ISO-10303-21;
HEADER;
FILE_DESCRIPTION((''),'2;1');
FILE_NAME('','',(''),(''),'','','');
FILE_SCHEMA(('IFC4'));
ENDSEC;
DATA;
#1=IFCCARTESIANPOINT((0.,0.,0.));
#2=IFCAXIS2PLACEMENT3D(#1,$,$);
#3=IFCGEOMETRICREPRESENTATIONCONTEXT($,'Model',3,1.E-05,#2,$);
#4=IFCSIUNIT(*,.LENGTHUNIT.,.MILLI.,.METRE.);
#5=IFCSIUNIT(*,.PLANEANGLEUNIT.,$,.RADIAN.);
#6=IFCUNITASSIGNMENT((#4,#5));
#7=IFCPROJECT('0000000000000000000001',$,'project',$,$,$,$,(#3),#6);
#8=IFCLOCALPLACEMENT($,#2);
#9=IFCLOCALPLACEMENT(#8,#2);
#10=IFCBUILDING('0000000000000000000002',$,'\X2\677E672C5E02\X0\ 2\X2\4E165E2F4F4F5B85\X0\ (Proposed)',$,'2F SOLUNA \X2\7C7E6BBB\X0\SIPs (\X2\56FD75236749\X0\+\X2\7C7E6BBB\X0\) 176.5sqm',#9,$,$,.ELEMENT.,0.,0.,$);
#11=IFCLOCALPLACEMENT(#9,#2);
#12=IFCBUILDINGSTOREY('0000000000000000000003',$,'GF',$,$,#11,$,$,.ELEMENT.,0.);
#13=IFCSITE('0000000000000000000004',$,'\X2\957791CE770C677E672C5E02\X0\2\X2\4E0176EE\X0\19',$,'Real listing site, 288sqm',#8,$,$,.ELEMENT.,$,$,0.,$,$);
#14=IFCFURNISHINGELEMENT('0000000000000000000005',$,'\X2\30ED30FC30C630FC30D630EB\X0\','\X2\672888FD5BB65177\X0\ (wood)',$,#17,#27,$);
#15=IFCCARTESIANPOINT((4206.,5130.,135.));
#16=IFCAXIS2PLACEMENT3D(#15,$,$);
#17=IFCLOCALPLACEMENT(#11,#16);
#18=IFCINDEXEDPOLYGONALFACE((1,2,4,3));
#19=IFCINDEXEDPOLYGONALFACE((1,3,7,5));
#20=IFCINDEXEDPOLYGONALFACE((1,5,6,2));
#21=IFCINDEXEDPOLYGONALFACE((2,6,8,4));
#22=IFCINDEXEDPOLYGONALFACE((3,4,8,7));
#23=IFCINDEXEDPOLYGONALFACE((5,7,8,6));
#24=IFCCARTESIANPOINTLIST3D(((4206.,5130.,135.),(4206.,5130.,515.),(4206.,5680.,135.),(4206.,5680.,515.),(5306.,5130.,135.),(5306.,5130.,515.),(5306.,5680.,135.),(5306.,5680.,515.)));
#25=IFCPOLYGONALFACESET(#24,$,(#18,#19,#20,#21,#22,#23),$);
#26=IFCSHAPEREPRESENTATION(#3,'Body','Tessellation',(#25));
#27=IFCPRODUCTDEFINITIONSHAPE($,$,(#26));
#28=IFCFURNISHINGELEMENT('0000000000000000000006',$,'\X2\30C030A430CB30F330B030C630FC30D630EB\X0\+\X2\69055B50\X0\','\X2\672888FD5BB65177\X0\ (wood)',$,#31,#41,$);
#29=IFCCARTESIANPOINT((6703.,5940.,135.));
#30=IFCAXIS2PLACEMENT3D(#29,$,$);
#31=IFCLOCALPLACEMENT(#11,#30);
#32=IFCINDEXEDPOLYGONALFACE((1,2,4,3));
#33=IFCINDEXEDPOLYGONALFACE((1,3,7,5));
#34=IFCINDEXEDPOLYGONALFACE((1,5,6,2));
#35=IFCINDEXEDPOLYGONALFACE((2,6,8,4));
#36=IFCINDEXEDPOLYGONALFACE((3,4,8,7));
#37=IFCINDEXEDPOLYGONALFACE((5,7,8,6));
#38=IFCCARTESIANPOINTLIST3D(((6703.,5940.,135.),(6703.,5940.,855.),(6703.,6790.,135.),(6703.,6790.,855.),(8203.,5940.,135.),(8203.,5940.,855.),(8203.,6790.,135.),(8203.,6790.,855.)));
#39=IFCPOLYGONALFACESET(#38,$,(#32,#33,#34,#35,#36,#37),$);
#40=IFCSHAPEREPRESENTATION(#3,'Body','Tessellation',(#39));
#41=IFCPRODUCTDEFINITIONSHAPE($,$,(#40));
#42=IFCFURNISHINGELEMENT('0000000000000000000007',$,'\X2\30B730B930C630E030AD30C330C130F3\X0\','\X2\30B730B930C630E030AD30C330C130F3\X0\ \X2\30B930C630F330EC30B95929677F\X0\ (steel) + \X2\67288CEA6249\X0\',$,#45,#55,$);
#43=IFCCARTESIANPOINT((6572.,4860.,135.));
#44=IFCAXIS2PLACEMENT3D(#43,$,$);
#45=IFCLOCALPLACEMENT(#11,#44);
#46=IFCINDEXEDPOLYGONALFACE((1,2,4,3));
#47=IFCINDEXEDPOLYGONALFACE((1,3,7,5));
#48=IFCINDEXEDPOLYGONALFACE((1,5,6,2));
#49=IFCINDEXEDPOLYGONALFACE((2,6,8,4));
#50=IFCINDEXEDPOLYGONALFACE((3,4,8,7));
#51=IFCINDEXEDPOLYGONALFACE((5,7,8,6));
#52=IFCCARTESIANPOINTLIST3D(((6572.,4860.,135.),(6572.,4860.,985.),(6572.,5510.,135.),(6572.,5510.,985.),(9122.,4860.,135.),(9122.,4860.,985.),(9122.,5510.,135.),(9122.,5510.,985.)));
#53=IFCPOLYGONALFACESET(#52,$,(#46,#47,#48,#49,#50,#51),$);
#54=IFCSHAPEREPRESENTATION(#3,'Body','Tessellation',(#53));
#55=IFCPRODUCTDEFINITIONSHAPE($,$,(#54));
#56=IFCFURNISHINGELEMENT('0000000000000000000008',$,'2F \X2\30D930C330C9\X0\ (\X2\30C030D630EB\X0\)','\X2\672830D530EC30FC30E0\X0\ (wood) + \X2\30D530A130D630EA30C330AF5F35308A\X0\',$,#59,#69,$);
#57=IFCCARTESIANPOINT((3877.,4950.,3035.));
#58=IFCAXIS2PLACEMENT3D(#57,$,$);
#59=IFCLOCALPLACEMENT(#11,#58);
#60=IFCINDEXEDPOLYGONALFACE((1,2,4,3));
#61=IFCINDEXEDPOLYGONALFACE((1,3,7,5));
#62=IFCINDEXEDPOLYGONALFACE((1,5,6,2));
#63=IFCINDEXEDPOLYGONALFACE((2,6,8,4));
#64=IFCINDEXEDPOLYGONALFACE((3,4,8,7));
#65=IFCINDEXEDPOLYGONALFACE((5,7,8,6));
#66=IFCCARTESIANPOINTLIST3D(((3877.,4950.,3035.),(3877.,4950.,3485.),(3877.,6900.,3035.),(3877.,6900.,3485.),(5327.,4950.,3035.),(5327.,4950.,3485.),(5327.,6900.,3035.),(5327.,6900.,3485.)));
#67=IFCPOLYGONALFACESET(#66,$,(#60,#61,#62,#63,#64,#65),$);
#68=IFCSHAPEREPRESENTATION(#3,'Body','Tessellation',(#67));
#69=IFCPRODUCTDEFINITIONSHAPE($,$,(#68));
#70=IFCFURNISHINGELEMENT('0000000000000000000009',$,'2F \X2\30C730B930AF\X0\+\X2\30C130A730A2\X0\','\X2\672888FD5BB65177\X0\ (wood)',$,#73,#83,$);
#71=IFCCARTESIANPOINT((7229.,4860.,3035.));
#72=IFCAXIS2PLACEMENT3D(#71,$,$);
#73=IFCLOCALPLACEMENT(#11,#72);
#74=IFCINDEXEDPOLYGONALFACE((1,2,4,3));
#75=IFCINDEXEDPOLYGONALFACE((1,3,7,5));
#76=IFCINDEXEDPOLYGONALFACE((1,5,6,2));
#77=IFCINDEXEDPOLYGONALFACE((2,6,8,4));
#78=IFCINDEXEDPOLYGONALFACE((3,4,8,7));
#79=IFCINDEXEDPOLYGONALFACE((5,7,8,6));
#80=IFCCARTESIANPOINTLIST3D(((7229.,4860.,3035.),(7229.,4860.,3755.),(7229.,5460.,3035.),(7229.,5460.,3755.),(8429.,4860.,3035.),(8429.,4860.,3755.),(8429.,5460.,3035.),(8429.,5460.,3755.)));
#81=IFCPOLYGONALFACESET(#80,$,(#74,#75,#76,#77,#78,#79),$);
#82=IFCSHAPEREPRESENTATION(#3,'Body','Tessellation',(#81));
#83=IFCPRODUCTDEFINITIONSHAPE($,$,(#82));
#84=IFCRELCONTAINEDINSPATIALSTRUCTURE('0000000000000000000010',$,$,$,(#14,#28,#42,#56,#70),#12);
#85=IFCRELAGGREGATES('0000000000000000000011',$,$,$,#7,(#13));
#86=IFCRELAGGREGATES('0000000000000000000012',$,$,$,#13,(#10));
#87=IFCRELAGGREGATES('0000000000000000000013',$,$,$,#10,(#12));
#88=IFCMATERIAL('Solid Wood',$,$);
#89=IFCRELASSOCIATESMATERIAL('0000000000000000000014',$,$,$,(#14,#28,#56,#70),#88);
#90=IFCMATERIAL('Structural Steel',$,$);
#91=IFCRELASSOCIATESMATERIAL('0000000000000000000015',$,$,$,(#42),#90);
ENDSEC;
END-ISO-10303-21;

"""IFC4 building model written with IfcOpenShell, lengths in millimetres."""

from ifc_helpers import new_model, si_unit, frame, frame_2d, origin, place, context, project, spatial, rectangle, extrude, material, element, save


model = new_model("IFC4")

# Units and contexts
model_context = context("Model", 3, precision=1e-05, world=origin())
ifc_project = project(units=[si_unit("LENGTHUNIT", "METRE", prefix="MILLI"), si_unit("PLANEANGLEUNIT", "RADIAN")], contexts=[model_context])

# Site, building, storey
site_placement = place(None, origin())
site = spatial("IfcSite", under=ifc_project, at=site_placement, Name="長野県松本市2丁目19", ObjectType="Real listing site, 288sqm", CompositionType="ELEMENT", RefElevation=0.0)
building_placement = place(site_placement, origin())
building = spatial("IfcBuilding", under=site, at=building_placement, Name="松本市 2世帯住宅 (Proposed)", ObjectType="2F SOLUNA 籾殻SIPs (国産杉+籾殻) 176.5sqm", CompositionType="ELEMENT", ElevationOfRefHeight=0.0, ElevationOfTerrain=0.0)
storey_placement = place(building_placement, origin())
storey = spatial("IfcBuildingStorey", under=building, at=storey_placement, Name="GF", CompositionType="ELEMENT", Elevation=0.0)

# Shared definitions
ifc_material_1 = material(Name="Solid Wood")

# Shared definitions
ifc_material_2 = material(Name="Structural Steel")

# Furnishing elements
furnishing_1_placement = place(storey_placement, frame((4206.0, 5130.0, 135.0)))
element("IfcFurnishingElement", 1, at=furnishing_1_placement, inside=storey, material=ifc_material_1, Name="ローテーブル", Description="木製家具 (wood)", context=model_context, shape_type="SweptSolid", body=[
    extrude(rectangle(XDim=1100.0, YDim=550.0, at=frame_2d((550.0, 275.0))), frame((4206.0, 5130.0, 135.0)), (0.0, 0.0, 1.0), 380.0),
])
furnishing_2_placement = place(storey_placement, frame((6703.0, 5940.0, 135.0)))
element("IfcFurnishingElement", 2, at=furnishing_2_placement, inside=storey, material=ifc_material_1, Name="ダイニングテーブル+椅子", Description="木製家具 (wood)", context=model_context, shape_type="SweptSolid", body=[
    extrude(rectangle(XDim=1500.0, YDim=850.0, at=frame_2d((750.0, 425.0))), frame((6703.0, 5940.0, 135.0)), (0.0, 0.0, 1.0), 720.0),
])
furnishing_3_placement = place(storey_placement, frame((6572.0, 4860.0, 135.0)))
element("IfcFurnishingElement", 3, at=furnishing_3_placement, inside=storey, material=ifc_material_2, Name="システムキッチン", Description="システムキッチン ステンレス天板 (steel) + 木質扉", context=model_context, shape_type="SweptSolid", body=[
    extrude(rectangle(XDim=2550.0, YDim=650.0, at=frame_2d((1275.0, 325.0))), frame((6572.0, 4860.0, 135.0)), (0.0, 0.0, 1.0), 850.0),
])
furnishing_4_placement = place(storey_placement, frame((3877.0, 4950.0, 3035.0)))
element("IfcFurnishingElement", 4, at=furnishing_4_placement, inside=storey, material=ifc_material_1, Name="2F ベッド (ダブル)", Description="木フレーム (wood) + ファブリック張り", context=model_context, shape_type="SweptSolid", body=[
    extrude(rectangle(XDim=1450.0, YDim=1950.0, at=frame_2d((725.0, 975.0))), frame((3877.0, 4950.0, 3035.0)), (0.0, 0.0, 1.0), 450.0),
])
furnishing_5_placement = place(storey_placement, frame((7229.0, 4860.0, 3035.0)))
element("IfcFurnishingElement", 5, at=furnishing_5_placement, inside=storey, material=ifc_material_1, Name="2F デスク+チェア", Description="木製家具 (wood)", context=model_context, shape_type="SweptSolid", body=[
    extrude(rectangle(XDim=1200.0, YDim=600.0, at=frame_2d((600.0, 300.0))), frame((7229.0, 4860.0, 3035.0)), (0.0, 0.0, 1.0), 720.0),
])

save(model, "model.ifc")
